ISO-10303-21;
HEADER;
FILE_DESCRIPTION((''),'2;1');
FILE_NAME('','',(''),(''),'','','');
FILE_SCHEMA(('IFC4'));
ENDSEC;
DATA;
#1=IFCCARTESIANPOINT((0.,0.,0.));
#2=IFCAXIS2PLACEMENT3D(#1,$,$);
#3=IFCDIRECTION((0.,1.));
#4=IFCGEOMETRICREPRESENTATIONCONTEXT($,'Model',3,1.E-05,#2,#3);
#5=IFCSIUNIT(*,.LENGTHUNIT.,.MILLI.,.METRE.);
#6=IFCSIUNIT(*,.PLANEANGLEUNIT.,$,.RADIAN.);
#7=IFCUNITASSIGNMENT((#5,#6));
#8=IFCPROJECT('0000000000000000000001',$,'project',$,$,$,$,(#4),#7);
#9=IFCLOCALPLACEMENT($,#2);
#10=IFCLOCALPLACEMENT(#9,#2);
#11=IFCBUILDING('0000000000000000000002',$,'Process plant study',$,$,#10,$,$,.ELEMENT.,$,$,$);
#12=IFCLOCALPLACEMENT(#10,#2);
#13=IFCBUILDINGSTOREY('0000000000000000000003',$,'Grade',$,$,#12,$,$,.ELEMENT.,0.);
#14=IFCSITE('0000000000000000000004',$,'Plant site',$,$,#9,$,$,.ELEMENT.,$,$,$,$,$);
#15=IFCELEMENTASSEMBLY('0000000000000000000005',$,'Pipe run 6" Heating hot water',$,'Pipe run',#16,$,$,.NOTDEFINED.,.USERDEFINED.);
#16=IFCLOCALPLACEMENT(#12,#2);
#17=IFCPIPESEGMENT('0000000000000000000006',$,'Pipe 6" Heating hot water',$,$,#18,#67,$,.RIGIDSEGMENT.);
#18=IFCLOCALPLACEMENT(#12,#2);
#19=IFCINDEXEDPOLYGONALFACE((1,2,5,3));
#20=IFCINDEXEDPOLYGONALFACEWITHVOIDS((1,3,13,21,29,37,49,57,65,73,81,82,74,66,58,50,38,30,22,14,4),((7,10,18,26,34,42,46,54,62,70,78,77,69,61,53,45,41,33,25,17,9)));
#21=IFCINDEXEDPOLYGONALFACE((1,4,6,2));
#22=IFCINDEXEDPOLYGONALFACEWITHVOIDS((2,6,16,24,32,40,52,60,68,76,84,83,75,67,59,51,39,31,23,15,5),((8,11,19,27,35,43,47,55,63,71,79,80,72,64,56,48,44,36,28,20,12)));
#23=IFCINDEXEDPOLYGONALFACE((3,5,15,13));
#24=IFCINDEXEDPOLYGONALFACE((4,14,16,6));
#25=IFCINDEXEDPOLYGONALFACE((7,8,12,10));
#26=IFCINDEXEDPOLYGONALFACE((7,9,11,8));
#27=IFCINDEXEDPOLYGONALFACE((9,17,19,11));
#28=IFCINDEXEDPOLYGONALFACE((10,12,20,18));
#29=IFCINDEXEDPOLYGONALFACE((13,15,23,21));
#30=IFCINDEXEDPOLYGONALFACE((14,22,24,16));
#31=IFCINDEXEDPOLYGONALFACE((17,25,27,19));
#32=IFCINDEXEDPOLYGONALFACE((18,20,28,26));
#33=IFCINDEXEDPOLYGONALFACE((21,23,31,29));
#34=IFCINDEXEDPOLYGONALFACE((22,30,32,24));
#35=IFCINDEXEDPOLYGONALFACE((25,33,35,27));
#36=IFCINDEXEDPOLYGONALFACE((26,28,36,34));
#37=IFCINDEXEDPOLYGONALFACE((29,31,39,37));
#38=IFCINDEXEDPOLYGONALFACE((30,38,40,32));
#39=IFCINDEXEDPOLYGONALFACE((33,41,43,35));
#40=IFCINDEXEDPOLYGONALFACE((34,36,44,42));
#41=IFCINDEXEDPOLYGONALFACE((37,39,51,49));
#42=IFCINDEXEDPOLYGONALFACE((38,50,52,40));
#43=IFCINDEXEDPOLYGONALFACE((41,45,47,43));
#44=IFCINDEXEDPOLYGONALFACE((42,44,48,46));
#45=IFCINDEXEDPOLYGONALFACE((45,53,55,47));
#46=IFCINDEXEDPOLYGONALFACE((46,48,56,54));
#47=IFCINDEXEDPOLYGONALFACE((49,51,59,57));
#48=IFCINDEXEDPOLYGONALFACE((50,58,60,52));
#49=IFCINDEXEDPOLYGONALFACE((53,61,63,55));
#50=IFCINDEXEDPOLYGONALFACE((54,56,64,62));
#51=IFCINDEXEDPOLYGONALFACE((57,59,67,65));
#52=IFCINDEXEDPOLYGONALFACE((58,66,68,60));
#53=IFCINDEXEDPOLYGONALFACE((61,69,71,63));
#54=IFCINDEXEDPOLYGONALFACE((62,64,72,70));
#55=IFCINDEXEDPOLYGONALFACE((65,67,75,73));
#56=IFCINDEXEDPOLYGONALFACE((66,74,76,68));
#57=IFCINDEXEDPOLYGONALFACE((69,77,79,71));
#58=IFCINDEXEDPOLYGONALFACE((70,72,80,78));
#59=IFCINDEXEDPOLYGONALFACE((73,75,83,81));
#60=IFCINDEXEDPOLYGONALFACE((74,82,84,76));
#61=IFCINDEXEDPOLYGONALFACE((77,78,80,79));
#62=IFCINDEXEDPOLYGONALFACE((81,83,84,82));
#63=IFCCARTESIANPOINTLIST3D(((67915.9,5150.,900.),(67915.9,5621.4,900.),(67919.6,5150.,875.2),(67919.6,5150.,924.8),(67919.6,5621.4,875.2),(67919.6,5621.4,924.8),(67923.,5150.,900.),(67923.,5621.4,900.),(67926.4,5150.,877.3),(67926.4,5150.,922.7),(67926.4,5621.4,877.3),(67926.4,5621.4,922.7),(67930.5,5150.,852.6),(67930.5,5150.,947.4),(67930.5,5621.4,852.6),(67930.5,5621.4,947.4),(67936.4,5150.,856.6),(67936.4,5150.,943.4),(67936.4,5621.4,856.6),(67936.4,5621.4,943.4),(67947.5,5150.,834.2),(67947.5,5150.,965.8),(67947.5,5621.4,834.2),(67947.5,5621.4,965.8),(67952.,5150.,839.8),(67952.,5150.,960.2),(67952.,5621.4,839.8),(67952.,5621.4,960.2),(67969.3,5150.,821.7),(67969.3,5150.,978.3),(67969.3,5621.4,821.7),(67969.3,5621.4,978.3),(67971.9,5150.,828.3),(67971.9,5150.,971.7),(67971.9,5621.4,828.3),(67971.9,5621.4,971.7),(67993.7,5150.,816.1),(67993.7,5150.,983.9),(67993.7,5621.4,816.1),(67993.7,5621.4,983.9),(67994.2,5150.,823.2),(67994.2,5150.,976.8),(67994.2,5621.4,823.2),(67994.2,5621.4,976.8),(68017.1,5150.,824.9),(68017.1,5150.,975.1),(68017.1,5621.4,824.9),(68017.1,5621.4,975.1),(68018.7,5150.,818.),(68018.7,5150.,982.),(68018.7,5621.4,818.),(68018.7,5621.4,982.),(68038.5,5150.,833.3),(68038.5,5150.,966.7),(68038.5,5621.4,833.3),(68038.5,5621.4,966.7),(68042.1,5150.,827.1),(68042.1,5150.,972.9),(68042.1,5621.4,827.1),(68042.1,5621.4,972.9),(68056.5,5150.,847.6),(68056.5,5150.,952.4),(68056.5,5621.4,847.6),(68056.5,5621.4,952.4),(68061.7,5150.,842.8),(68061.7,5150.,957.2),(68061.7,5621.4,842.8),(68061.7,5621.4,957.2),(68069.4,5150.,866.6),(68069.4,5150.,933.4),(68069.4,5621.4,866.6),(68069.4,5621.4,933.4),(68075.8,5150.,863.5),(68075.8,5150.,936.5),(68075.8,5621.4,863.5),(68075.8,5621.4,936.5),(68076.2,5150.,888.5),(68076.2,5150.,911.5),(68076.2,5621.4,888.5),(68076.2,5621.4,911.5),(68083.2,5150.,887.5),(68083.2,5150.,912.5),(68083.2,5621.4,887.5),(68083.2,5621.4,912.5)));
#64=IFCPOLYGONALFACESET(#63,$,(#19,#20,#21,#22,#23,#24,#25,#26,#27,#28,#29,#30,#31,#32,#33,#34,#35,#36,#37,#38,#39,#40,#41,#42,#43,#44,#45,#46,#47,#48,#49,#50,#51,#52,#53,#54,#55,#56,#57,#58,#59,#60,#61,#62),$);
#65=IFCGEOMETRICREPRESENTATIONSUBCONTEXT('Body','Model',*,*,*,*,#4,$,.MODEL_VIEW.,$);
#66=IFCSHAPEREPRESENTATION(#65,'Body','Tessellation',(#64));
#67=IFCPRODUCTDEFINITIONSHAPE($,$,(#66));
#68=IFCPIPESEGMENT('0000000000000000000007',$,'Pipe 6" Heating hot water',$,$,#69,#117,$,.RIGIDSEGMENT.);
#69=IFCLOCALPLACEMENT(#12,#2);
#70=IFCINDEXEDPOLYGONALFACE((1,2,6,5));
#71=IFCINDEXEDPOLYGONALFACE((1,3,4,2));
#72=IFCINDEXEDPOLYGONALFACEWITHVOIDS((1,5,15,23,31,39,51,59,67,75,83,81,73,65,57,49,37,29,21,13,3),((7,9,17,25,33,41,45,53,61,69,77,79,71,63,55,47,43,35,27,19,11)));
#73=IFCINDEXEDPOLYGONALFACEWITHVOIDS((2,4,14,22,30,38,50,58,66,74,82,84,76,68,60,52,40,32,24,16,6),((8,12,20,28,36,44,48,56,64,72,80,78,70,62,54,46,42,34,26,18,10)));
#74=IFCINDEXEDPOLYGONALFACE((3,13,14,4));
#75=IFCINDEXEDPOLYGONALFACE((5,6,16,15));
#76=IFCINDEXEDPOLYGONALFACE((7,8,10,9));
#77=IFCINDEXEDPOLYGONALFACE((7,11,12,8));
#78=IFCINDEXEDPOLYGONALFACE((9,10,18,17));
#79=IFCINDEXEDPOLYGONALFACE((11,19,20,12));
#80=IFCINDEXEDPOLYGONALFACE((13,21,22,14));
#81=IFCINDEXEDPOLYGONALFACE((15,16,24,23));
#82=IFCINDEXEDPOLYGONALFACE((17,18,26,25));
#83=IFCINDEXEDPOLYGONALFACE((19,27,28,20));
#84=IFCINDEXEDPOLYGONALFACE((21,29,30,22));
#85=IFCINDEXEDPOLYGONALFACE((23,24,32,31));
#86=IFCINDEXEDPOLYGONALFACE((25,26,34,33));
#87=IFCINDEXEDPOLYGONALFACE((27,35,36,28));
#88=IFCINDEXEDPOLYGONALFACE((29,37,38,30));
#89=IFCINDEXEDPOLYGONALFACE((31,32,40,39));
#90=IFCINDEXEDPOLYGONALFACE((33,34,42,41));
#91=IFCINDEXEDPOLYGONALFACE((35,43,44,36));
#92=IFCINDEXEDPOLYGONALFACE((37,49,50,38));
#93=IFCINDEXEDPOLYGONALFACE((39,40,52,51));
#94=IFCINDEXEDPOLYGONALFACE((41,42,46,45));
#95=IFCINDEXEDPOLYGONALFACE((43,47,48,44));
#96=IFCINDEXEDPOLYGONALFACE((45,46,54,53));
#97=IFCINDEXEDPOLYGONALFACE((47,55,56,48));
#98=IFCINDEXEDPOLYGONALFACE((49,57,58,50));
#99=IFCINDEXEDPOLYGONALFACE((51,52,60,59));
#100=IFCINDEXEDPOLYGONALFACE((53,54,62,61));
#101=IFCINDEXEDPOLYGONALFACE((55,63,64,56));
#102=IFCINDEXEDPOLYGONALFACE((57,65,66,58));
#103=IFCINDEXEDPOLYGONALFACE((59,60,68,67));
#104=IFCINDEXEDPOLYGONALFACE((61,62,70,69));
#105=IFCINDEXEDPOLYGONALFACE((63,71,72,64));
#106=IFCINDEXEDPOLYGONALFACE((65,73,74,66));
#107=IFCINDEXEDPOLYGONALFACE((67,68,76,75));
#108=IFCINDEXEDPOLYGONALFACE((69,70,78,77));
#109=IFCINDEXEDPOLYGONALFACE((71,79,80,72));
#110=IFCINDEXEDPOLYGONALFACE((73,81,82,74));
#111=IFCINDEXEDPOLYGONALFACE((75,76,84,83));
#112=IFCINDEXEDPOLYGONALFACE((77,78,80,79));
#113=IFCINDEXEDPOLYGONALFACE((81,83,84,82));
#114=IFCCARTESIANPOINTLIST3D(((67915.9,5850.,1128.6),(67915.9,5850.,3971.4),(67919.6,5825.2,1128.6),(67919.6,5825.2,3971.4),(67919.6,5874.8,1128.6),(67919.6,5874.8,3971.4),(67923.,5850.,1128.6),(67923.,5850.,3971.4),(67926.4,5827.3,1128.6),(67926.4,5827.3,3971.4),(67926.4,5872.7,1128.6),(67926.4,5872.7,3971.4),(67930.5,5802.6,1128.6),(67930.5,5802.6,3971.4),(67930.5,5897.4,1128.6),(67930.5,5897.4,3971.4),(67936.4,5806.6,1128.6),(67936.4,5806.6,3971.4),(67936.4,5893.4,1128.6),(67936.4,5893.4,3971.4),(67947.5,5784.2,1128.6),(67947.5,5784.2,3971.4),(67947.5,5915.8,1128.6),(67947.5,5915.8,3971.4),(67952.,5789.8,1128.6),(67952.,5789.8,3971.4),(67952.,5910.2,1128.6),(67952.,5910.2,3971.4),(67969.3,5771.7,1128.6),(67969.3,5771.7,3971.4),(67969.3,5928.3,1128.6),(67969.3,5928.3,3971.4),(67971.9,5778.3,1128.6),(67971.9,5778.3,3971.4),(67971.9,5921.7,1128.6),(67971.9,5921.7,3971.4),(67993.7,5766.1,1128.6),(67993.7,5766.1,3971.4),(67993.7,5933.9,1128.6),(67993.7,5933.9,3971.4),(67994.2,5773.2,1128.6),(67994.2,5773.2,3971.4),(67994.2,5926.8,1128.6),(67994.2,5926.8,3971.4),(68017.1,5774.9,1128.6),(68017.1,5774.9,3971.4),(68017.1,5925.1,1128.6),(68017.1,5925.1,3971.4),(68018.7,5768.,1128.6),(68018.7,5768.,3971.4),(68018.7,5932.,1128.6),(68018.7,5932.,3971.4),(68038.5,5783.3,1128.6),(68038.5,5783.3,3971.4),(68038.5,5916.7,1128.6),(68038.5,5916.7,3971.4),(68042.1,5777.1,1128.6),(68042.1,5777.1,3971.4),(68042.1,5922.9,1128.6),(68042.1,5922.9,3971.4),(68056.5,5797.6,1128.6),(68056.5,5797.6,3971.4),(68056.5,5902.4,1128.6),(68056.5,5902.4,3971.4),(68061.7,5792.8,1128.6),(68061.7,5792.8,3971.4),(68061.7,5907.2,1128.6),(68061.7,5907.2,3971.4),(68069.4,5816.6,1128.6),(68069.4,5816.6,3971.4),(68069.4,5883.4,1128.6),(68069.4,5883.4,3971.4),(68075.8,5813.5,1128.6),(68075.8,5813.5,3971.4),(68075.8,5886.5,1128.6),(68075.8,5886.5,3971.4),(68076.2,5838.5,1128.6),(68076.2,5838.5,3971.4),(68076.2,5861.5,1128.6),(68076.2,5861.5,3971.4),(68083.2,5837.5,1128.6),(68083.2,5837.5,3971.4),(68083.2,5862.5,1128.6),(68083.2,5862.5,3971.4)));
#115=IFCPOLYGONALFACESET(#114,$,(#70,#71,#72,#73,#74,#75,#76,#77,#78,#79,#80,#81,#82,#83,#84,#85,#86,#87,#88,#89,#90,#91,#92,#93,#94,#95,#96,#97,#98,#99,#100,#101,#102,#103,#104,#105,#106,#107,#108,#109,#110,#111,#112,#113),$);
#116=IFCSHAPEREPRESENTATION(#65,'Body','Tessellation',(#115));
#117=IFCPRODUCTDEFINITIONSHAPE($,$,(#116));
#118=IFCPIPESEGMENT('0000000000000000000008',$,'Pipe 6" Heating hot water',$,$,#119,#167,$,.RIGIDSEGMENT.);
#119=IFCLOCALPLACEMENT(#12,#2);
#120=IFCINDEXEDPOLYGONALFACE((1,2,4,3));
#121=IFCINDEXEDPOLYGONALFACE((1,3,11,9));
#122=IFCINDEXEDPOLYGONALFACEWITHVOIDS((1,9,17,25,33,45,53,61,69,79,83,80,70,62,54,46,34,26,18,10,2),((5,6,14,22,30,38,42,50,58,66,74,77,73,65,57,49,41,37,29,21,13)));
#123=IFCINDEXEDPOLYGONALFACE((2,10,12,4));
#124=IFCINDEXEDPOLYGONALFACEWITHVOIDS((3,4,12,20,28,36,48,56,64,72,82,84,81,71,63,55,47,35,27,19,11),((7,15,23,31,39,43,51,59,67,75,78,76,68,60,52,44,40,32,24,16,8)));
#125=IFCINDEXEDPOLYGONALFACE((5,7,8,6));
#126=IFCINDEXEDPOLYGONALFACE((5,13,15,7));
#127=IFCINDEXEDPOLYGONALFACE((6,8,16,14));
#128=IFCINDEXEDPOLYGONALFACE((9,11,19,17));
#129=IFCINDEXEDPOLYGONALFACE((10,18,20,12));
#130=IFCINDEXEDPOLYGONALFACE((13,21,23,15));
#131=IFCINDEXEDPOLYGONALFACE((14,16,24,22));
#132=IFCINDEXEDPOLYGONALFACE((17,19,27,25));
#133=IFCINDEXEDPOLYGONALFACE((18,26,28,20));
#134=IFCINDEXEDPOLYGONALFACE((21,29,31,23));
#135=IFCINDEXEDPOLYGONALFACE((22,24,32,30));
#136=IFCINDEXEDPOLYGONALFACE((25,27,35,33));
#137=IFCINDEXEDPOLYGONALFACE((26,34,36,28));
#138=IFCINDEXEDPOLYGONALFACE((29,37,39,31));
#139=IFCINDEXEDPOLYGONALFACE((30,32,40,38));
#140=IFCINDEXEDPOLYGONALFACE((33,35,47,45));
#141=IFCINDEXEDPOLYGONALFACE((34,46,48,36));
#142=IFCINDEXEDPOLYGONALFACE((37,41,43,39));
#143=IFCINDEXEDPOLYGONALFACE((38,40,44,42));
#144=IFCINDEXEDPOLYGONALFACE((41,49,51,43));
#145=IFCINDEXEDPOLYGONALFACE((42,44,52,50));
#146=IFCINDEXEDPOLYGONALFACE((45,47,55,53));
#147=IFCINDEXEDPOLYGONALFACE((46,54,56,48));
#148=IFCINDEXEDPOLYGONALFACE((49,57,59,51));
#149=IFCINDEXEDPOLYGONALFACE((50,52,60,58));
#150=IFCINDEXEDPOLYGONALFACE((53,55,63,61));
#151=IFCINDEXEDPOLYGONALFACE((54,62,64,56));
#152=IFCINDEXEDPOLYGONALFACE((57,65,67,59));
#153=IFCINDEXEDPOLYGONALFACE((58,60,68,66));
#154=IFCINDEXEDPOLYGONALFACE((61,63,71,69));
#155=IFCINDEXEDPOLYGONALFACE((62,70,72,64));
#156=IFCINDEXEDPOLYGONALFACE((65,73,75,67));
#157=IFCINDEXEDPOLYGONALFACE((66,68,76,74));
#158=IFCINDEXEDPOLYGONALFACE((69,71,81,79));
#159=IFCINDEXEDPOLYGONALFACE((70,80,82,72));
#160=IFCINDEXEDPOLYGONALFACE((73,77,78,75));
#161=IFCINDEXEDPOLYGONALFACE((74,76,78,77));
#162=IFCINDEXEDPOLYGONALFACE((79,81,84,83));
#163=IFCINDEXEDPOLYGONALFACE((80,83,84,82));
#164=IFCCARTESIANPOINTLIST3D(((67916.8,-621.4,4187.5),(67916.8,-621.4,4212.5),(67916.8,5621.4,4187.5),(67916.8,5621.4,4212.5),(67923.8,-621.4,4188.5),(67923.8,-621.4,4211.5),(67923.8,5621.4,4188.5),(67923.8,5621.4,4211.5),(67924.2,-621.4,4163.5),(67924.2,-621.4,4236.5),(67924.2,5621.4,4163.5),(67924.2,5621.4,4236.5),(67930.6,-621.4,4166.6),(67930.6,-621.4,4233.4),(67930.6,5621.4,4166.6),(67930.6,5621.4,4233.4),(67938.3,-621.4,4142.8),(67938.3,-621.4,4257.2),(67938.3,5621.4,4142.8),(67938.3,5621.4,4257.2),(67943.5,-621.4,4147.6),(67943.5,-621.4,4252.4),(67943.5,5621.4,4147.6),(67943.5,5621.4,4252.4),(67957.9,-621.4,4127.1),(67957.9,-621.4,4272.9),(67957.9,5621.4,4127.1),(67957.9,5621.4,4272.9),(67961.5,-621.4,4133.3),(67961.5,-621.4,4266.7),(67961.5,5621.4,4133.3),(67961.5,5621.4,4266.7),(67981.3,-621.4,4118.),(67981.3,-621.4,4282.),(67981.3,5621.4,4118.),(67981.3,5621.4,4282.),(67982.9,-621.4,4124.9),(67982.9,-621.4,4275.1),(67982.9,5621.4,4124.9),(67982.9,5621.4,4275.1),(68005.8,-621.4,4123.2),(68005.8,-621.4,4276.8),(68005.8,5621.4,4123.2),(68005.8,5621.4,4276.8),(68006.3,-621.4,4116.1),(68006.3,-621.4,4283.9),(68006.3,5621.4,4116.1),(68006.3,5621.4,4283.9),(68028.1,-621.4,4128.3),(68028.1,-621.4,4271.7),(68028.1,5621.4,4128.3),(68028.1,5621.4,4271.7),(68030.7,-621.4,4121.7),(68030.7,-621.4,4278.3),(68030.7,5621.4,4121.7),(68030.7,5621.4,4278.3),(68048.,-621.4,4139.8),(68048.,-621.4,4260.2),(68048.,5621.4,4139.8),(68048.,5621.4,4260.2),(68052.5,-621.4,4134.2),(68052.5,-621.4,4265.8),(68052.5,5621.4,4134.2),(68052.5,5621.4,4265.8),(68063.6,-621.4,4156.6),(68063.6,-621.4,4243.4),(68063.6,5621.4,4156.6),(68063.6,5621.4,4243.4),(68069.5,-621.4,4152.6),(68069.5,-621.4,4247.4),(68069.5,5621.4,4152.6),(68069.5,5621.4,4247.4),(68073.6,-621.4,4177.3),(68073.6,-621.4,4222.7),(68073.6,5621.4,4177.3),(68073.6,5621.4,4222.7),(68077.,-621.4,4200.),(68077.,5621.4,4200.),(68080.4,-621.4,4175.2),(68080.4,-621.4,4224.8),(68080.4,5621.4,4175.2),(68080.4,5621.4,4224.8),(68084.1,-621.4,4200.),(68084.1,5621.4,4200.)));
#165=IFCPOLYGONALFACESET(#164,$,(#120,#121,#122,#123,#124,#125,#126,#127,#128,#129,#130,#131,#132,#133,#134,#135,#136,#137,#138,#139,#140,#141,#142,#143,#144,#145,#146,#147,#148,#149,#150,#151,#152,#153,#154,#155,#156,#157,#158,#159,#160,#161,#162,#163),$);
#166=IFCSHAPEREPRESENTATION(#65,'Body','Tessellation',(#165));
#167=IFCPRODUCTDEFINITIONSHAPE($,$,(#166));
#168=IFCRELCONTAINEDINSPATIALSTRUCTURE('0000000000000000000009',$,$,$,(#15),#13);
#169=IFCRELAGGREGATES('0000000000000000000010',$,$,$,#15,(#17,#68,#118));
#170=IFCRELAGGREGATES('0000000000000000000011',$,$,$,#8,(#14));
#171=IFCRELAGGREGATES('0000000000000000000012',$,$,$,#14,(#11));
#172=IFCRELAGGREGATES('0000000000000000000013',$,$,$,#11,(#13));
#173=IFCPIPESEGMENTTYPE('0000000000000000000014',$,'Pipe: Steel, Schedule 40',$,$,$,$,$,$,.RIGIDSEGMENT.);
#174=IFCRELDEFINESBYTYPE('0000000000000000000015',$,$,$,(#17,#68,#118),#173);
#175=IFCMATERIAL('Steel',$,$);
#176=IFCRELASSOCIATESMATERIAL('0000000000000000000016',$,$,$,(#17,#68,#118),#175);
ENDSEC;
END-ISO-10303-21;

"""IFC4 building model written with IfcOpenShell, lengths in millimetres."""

from ifc_helpers import new_model, si_unit, direction, frame, origin, origin_with_axes, origin_2d, place, context, subcontext, project, spatial, hollow_circle, extrude, material, type_object, element, aggregate, save


model = new_model("IFC4")

# Units and contexts
model_context = context("Model", 3, precision=1e-05, world=origin(), true_north=direction((0.0, 1.0)))
body_context = subcontext(model_context, "Body", "Model", "MODEL_VIEW")
ifc_project = project(units=[si_unit("LENGTHUNIT", "METRE", prefix="MILLI"), si_unit("PLANEANGLEUNIT", "RADIAN")], contexts=[model_context])

# Site, building, storey
site_placement = place(None, origin())
site = spatial("IfcSite", under=ifc_project, at=site_placement, Name="Plant site", CompositionType="ELEMENT")
building_placement = place(site_placement, origin())
building = spatial("IfcBuilding", under=site, at=building_placement, Name="Process plant study", CompositionType="ELEMENT")
storey_placement = place(building_placement, origin())
storey = spatial("IfcBuildingStorey", under=building, at=storey_placement, Name="Grade", CompositionType="ELEMENT", Elevation=0.0)

# Element assembly, pipe segments
ifc_material = material(Name="Steel")
pipe_segment_type = type_object("IfcPipeSegmentType", Name="Pipe: Steel, Schedule 40", PredefinedType="RIGIDSEGMENT")
assembly_1_placement = place(storey_placement, origin_with_axes())
assembly_1 = element("IfcElementAssembly", 1, at=assembly_1_placement, inside=storey, Name="Pipe run 6\" Heating hot water", ObjectType="Pipe run", AssemblyPlace="NOTDEFINED", PredefinedType="USERDEFINED")
pipe_segment_1_placement = place(storey_placement, origin_with_axes())
pipe_segment_1 = element("IfcPipeSegment", 2, at=pipe_segment_1_placement, type_object=pipe_segment_type, material=ifc_material, Name="Pipe 6\" Heating hot water", PredefinedType="RIGIDSEGMENT", context=body_context, shape_type="SweptSolid", body=[
    extrude(hollow_circle(Radius=84.1, WallThickness=7.1, at=origin_2d()), frame((68000.0, 5150.0, 900.0), z_axis=(0.0, 1.0, 0.0), x_axis=(-1.0, 0.0, 0.0)), (0.0, 0.0, 1.0), 471.4),
])
pipe_segment_2_placement = place(storey_placement, origin_with_axes())
pipe_segment_2 = element("IfcPipeSegment", 3, at=pipe_segment_2_placement, type_object=pipe_segment_type, material=ifc_material, Name="Pipe 6\" Heating hot water", PredefinedType="RIGIDSEGMENT", context=body_context, shape_type="SweptSolid", body=[
    extrude(hollow_circle(Radius=84.1, WallThickness=7.1, at=origin_2d()), frame((68000.0, 5850.0, 1128.6), z_axis=(0.0, 0.0, 1.0), x_axis=(-1.0, 0.0, 0.0)), (0.0, 0.0, 1.0), 2842.8),
])
pipe_segment_3_placement = place(storey_placement, origin_with_axes())
pipe_segment_3 = element("IfcPipeSegment", 4, at=pipe_segment_3_placement, type_object=pipe_segment_type, material=ifc_material, Name="Pipe 6\" Heating hot water", PredefinedType="RIGIDSEGMENT", context=body_context, shape_type="SweptSolid", body=[
    extrude(hollow_circle(Radius=84.1, WallThickness=7.1, at=origin_2d()), frame((68000.0, 5621.4, 4200.0), z_axis=(0.0, -1.0, 0.0), x_axis=(1.0, 0.0, 0.0)), (0.0, 0.0, 1.0), 6242.8),
])

aggregate(assembly_1, [pipe_segment_1, pipe_segment_2, pipe_segment_3])

save(model, "model.ifc")
